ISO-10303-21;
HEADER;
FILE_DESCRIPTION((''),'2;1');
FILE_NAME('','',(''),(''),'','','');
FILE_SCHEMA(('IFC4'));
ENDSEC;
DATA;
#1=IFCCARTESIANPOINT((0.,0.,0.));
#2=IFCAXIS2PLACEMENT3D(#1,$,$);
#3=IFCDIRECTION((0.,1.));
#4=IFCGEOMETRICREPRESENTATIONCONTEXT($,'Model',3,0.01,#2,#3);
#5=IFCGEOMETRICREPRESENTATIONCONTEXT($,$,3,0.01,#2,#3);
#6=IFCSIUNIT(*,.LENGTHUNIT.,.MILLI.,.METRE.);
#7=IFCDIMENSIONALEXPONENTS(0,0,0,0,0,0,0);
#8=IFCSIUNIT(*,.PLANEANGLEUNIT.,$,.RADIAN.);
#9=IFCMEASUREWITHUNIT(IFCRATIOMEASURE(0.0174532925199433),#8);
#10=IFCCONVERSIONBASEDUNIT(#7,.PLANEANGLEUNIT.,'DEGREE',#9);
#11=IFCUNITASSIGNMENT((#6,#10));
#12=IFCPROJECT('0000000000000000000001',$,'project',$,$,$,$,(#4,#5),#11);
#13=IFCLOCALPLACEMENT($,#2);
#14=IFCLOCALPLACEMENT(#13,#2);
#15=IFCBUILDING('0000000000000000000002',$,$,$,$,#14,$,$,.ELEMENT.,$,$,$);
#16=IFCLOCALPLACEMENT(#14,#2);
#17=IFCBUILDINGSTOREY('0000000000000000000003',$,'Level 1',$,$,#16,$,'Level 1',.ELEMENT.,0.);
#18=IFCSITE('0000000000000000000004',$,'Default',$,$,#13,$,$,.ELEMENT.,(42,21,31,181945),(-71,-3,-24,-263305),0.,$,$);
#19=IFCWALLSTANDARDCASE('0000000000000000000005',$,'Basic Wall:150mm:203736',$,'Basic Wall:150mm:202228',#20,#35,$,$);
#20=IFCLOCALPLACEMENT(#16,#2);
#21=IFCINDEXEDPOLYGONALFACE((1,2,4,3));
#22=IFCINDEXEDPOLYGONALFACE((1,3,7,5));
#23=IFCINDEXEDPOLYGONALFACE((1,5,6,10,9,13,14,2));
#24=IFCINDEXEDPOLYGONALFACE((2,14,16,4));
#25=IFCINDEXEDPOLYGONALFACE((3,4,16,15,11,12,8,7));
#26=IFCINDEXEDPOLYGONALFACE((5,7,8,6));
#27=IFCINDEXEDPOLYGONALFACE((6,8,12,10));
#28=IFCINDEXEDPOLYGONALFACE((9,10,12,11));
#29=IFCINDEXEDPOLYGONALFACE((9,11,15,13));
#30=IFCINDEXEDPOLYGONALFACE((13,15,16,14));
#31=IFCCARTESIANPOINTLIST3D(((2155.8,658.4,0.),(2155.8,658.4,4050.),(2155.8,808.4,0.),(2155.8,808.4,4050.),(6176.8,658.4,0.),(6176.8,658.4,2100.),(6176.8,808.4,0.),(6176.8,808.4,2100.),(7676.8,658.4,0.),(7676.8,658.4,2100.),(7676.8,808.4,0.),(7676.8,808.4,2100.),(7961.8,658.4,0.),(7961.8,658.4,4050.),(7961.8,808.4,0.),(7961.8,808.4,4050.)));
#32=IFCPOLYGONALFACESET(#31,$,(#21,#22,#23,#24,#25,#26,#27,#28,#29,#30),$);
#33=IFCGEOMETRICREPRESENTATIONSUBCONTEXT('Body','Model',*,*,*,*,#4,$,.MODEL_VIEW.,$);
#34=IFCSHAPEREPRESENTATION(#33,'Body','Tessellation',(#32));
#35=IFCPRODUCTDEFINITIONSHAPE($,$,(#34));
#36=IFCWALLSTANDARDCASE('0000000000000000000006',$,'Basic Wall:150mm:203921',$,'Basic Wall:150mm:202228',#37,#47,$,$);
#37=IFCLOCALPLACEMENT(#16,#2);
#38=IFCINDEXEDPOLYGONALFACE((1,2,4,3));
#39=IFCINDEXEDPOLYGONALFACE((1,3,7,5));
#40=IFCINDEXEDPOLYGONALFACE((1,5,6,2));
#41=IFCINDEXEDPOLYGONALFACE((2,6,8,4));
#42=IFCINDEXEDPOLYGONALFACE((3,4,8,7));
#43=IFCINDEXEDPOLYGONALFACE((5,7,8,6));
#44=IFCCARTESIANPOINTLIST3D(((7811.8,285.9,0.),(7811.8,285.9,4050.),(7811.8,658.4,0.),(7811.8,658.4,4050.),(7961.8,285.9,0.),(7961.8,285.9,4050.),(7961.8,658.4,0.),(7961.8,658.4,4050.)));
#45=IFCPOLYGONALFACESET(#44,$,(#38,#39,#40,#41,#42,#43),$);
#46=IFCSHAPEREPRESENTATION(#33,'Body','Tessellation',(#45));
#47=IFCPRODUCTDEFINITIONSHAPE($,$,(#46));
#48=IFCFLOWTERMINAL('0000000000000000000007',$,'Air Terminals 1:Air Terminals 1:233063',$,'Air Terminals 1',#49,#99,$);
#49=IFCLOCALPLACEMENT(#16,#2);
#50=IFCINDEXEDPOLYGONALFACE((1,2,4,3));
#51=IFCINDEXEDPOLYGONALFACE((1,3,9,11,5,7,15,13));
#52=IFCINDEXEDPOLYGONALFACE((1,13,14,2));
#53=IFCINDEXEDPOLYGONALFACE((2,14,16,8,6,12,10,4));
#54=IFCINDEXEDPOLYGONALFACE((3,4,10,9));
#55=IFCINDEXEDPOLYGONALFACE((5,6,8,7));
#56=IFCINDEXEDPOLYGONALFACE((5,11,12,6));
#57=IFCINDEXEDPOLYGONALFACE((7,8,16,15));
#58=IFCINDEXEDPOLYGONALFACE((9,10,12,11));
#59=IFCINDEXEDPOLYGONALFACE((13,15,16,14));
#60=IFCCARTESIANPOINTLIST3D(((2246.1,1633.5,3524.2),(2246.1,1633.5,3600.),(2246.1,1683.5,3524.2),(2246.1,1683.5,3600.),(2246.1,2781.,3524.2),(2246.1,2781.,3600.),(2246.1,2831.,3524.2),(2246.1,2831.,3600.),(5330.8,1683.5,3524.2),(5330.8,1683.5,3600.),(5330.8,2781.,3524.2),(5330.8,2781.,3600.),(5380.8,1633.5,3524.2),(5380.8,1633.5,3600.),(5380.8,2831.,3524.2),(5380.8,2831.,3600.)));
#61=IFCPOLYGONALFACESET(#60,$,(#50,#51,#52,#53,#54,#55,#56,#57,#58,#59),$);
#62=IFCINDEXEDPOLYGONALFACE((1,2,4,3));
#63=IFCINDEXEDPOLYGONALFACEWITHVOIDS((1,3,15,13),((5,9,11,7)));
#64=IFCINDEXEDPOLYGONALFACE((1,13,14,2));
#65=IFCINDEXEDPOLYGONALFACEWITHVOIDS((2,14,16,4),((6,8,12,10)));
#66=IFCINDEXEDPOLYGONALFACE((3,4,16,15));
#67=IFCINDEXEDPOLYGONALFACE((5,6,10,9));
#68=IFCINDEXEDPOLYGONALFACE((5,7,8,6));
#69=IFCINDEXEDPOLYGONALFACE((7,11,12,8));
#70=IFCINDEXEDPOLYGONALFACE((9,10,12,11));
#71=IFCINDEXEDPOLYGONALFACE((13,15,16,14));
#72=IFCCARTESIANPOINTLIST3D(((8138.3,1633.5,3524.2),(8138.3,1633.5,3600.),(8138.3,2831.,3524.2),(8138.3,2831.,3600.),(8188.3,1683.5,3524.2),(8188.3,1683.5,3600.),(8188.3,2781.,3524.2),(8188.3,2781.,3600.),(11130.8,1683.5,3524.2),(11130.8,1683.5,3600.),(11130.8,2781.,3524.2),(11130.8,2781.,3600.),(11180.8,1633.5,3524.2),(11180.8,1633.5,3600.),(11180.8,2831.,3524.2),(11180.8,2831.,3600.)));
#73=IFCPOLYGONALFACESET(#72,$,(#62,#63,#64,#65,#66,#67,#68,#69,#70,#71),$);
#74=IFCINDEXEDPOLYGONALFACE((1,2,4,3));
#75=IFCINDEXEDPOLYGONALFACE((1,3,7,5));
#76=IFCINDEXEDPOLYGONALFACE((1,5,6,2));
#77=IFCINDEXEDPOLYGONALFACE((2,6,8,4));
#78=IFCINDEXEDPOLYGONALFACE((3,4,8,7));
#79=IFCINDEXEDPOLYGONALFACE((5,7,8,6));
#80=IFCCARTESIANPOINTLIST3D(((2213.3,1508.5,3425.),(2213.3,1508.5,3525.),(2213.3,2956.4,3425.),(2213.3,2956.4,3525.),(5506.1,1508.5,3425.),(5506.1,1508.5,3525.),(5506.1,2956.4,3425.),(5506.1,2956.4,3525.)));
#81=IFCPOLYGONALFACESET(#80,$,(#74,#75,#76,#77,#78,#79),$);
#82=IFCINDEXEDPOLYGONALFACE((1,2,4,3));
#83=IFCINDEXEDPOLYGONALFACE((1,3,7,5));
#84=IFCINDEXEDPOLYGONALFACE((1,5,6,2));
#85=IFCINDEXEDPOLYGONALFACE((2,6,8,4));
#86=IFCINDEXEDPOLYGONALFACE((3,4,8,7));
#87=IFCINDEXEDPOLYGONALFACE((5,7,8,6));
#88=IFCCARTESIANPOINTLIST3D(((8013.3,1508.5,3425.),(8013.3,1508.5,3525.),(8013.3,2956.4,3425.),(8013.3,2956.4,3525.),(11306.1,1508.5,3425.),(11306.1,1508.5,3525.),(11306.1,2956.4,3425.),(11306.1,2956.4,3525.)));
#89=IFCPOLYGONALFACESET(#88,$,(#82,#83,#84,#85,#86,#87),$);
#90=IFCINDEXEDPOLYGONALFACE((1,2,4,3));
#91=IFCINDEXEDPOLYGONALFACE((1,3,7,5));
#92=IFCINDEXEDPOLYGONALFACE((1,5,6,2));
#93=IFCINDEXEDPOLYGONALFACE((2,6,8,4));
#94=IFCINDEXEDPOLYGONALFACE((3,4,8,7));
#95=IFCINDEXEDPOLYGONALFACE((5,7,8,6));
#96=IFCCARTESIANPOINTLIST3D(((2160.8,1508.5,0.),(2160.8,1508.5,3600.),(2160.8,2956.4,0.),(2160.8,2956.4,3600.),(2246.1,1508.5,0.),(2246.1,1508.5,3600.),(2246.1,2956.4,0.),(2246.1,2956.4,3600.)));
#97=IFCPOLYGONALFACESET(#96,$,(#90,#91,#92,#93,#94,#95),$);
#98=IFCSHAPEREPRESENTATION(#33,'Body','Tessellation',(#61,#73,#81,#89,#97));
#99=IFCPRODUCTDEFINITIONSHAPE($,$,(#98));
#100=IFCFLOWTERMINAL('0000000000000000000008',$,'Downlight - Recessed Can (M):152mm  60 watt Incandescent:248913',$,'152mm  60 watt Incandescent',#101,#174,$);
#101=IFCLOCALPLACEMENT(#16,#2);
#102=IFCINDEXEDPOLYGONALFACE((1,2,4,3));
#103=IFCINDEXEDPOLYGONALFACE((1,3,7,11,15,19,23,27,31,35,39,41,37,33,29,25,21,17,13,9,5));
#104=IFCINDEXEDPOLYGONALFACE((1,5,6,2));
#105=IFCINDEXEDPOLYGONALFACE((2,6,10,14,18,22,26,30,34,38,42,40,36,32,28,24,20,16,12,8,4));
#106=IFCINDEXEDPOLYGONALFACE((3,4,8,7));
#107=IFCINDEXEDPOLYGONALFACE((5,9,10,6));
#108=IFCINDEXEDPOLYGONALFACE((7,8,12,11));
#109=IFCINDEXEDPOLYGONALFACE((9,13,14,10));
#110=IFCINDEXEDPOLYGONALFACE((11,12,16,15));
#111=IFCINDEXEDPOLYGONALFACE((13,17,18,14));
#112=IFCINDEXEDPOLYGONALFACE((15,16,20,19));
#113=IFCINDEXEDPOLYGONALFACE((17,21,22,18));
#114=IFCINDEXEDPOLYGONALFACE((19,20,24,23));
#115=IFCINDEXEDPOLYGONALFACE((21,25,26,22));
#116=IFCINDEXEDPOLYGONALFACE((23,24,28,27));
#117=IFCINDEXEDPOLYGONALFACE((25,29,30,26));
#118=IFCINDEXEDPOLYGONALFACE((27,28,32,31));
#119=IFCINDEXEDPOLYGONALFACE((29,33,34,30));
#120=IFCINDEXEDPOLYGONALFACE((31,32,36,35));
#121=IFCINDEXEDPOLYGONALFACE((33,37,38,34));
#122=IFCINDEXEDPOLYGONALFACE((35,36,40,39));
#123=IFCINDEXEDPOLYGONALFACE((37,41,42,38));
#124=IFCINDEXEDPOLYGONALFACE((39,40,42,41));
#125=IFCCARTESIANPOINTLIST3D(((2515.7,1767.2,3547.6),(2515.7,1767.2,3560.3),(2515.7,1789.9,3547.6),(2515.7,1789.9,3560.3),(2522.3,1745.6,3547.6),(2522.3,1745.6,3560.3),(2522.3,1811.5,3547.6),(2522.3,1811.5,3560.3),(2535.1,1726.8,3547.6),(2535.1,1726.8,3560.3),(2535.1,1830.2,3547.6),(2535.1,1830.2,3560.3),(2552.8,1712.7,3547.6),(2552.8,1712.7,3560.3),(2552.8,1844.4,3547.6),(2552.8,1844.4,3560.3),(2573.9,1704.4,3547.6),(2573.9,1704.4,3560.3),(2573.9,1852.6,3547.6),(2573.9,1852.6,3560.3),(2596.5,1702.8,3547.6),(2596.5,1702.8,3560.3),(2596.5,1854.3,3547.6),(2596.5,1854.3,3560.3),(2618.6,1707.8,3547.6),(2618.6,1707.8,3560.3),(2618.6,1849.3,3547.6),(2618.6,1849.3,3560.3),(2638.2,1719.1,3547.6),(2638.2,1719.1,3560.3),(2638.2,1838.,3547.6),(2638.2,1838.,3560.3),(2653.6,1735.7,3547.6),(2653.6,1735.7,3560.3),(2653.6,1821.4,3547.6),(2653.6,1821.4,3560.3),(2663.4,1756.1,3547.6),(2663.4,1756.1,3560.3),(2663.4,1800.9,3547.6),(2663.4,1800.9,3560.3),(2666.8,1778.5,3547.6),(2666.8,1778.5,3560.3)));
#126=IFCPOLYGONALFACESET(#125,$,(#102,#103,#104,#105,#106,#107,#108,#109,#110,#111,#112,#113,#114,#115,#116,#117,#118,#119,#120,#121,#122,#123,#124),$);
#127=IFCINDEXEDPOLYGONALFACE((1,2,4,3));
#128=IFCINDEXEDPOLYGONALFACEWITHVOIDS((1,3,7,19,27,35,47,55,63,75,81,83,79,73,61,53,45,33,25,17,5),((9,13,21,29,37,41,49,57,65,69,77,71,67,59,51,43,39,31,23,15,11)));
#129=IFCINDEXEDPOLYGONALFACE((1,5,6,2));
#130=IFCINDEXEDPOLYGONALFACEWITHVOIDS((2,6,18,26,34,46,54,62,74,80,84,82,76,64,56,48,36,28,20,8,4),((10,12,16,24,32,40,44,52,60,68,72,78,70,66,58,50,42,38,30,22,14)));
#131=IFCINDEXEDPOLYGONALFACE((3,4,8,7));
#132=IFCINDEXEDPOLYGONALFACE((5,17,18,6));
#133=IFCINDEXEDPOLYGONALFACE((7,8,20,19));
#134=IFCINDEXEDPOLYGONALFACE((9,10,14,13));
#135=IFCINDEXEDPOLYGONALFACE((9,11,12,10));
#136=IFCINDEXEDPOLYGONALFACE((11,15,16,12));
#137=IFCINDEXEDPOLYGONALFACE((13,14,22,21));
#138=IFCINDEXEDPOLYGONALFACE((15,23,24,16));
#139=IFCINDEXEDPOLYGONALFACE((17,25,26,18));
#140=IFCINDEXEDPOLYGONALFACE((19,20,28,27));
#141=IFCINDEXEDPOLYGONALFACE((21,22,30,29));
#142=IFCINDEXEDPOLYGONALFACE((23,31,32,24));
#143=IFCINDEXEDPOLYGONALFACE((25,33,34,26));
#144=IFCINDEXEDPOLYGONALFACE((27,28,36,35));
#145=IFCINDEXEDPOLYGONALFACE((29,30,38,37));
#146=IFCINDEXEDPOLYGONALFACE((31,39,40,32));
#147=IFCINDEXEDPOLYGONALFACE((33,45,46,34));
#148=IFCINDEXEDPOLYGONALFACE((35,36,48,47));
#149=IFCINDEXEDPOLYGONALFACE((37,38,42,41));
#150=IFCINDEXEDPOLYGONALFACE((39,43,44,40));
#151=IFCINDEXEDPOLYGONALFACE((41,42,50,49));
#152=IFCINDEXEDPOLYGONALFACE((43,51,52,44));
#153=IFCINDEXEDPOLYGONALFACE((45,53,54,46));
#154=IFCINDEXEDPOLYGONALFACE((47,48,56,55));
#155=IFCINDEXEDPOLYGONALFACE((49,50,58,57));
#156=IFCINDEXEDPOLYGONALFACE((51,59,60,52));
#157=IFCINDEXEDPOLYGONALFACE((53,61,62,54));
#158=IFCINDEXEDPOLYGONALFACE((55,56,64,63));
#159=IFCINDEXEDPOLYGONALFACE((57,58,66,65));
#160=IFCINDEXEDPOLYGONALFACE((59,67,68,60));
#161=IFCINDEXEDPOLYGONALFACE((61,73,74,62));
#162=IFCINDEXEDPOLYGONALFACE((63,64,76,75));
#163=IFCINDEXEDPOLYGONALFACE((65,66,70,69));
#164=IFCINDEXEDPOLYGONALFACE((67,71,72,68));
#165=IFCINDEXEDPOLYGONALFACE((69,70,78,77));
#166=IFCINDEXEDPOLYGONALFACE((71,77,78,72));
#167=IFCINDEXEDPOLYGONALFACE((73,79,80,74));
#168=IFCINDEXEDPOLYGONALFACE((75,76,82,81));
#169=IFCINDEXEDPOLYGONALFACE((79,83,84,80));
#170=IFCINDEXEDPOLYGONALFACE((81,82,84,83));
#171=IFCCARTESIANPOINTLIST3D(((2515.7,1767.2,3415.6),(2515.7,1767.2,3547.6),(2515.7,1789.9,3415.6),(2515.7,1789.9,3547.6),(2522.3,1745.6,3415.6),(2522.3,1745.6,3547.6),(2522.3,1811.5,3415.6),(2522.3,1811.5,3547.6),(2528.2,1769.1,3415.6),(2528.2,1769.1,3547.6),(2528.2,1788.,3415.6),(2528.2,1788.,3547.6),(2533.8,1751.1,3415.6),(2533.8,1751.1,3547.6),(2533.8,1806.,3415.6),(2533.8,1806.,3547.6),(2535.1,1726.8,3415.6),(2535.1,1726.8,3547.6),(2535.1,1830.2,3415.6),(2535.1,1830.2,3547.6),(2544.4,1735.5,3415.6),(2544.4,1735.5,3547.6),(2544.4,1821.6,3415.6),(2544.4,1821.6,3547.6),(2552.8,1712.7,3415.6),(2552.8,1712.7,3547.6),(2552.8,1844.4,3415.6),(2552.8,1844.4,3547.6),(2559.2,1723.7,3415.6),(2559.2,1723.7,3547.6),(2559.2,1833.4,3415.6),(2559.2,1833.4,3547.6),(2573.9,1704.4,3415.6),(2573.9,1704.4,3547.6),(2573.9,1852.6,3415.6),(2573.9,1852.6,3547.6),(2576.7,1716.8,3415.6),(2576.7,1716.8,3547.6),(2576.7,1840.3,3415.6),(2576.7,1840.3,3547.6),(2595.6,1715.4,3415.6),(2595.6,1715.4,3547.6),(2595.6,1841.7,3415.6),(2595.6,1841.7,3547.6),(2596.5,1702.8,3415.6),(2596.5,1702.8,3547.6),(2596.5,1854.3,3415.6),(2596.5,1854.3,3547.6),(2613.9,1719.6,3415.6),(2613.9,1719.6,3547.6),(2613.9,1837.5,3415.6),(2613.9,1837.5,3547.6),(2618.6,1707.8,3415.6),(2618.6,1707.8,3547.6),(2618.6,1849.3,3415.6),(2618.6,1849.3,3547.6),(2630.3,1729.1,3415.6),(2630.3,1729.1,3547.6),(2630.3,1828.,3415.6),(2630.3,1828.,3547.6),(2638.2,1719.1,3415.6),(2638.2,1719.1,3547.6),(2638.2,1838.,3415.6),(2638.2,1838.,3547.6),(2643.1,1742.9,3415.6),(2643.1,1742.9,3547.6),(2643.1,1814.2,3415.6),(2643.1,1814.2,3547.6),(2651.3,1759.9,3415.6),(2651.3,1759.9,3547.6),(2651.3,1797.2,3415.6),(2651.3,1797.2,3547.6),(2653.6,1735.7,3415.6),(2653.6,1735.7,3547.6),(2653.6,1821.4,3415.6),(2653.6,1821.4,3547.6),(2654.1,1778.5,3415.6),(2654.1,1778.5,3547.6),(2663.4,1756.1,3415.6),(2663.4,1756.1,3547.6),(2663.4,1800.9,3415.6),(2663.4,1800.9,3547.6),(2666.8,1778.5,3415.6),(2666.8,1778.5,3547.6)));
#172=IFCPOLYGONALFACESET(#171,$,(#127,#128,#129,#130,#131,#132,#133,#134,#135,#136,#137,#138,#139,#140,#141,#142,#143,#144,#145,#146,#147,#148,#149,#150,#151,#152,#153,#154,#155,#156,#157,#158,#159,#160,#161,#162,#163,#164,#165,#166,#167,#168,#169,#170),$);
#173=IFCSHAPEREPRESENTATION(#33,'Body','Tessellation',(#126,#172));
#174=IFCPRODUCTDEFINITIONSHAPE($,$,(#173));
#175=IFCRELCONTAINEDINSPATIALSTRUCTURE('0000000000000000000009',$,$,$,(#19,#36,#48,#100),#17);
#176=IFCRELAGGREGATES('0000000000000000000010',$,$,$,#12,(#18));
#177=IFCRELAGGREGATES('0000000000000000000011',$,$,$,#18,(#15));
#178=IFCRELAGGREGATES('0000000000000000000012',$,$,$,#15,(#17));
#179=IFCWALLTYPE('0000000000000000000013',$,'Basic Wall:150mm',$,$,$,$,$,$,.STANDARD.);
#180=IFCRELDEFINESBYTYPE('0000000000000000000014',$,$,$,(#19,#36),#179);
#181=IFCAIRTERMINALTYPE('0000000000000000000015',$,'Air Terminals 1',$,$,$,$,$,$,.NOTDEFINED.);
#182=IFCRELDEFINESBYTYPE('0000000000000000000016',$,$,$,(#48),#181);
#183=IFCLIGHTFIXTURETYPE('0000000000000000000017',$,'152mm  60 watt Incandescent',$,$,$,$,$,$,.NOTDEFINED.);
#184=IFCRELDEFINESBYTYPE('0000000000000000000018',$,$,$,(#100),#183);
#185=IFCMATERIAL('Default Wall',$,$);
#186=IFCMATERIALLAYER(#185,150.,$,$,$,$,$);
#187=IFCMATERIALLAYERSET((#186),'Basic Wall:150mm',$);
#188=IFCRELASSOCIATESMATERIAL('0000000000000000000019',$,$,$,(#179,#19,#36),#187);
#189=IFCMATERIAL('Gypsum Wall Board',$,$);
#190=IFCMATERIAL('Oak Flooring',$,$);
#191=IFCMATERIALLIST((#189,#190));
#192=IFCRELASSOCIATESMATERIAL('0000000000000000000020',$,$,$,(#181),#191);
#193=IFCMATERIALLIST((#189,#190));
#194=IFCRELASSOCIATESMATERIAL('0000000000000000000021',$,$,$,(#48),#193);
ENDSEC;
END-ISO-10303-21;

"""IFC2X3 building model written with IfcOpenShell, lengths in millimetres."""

from ifc_helpers import new_model, entity, si_unit, converted_unit, direction, frame, frame_2d, origin, origin_2d_with_axis, place, context, subcontext, project, spatial, polyline, rectangle, circle, hollow_circle, outline, extrude, source, transform, mapped, material, material_list, layer, layer_set, layer_usage, type_object, type_shapes, element, save


model = new_model("IFC2X3")

# Units and contexts
model_context = context("Model", 3, precision=0.01, world=origin(), true_north=direction((0.0, 1.0)))
context_of_model = context(None, 3, precision=0.01, world=origin(), true_north=direction((0.0, 1.0)))
body_context = subcontext(model_context, "Body", "Model", "MODEL_VIEW")
ifc_project = project(units=[si_unit("LENGTHUNIT", "METRE", prefix="MILLI"), converted_unit("PLANEANGLEUNIT", "DEGREE", entity("IfcRatioMeasure", 0.0174532925199433), si_unit("PLANEANGLEUNIT", "RADIAN"), dimensions=[0, 0, 0, 0, 0, 0, 0])], contexts=[model_context, context_of_model])

# Site, building, storey
site_placement = place(None, origin())
site = spatial("IfcSite", under=ifc_project, at=site_placement, Name="Default", CompositionType="ELEMENT", RefLatitude=(42, 21, 31, 181945), RefLongitude=(-71, -3, -24, -263305), RefElevation=0.0)
building_placement = place(site_placement, origin())
building = spatial("IfcBuilding", under=site, at=building_placement, CompositionType="ELEMENT")
storey_placement = place(building_placement, origin())
storey = spatial("IfcBuildingStorey", under=building, at=storey_placement, Name="Level 1", LongName="Level 1", CompositionType="ELEMENT", Elevation=0.0)

# Shared definitions
ifc_material_1 = material(Name="Default Wall")

# Shared definitions
ifc_layer_1 = layer(ifc_material_1, 150.0)
ifc_layer_set_1 = layer_set([ifc_layer_1], Name="Basic Wall:150mm")
wall_type_1 = type_object("IfcWallType", Name="Basic Wall:150mm", PredefinedType="STANDARD", material=ifc_layer_set_1)

# Wall, opening
ifc_layer_usage_1 = layer_usage(ifc_layer_set_1, "AXIS2", "NEGATIVE", 75.0)
wall_1_placement = place(storey_placement, frame((2155.8, 733.4, 0.0)))
wall_1 = element("IfcWallStandardCase", 1, at=wall_1_placement, inside=storey, type_object=wall_type_1, material=ifc_layer_usage_1, Name="Basic Wall:150mm:203736", ObjectType="Basic Wall:150mm:202228", context=body_context, shape_type="SweptSolid", body=[
    extrude(rectangle(XDim=5806.0, YDim=150.0, at=frame_2d((2903.0, 0.0), x_axis=(-1.0, 0.0))), origin(), (0.0, 0.0, 1.0), 4050.0),
])
opening_1_placement = place(wall_1_placement, frame((5521.0, 75.0, 0.0)))
element("IfcOpeningElement", 2, at=opening_1_placement, cuts=wall_1, ObjectType="Opening", context=body_context, shape_type="SweptSolid", body=[
    extrude(rectangle(XDim=2100.0, YDim=1500.0, at=frame_2d((1050.0, 750.0), x_axis=(1.0, 0.0))), frame((0.0, 0.0, 0.0), z_axis=(0.0, -1.0, 0.0), x_axis=(0.0, 0.0, 1.0)), (0.0, 0.0, 1.0), 150.0),
])

# Wall
ifc_layer_usage_2 = layer_usage(ifc_layer_set_1, "AXIS2", "NEGATIVE", 75.0)
wall_2_placement = place(storey_placement, frame((7886.8, 658.4, 0.0), z_axis=(0.0, 0.0, 1.0), x_axis=(0.0, -1.0, 0.0)))
element("IfcWallStandardCase", 3, at=wall_2_placement, inside=storey, type_object=wall_type_1, material=ifc_layer_usage_2, Name="Basic Wall:150mm:203921", ObjectType="Basic Wall:150mm:202228", context=body_context, shape_type="SweptSolid", body=[
    extrude(rectangle(XDim=372.5, YDim=150.0, at=frame_2d((186.2, 0.0), x_axis=(-1.0, 0.0))), origin(), (0.0, 0.0, 1.0), 4050.0),
])

# Shared definitions
ifc_material_2 = material(Name="Gypsum Wall Board")

# Flow terminals
ifc_material_3 = material(Name="Oak Flooring")
ifc_material_list_1 = material_list([ifc_material_2, ifc_material_3])
ifc_material_list_2 = material_list([ifc_material_2, ifc_material_3])
air_terminal_type = type_object("IfcAirTerminalType", Name="Air Terminals 1", PredefinedType="NOTDEFINED", material=ifc_material_list_2)
shared_shape_1 = source(origin(), body_context, "Body", "SweptSolid", [
    extrude(outline(polyline([(-1554.9, -598.8), (1579.9, -598.8), (1579.9, 598.7), (-1554.9, 598.7), (-1554.9, 548.7), (1529.9, 548.7), (1529.9, -548.8), (-1554.9, -548.8), (-1554.9, -598.8)])), frame((3800.9, 2232.2, 3524.2)), (0.0, 0.0, 1.0), 75.8),
    extrude(outline(polyline([(-1521.2, -598.8), (1521.2, -598.8), (1521.2, 598.7), (-1521.2, 598.7), (-1521.2, -598.8)]), holes=[polyline([(-1471.2, -548.8), (-1471.2, 548.7), (1471.2, 548.7), (1471.2, -548.8), (-1471.2, -548.8)])]), frame((9659.6, 2232.2, 3524.2)), (0.0, 0.0, 1.0), 75.8),
    extrude(rectangle(XDim=1447.9, YDim=3292.8, at=frame_2d((0.0, 0.0), x_axis=(1.0, 0.0))), frame((3859.7, 2232.5, 3425.0), z_axis=(0.0, 0.0, 1.0), x_axis=(0.0, 1.0, 0.0)), (0.0, 0.0, 1.0), 100.0),
    extrude(rectangle(XDim=1447.9, YDim=3292.8, at=origin_2d_with_axis()), frame((9659.7, 2232.5, 3425.0), z_axis=(0.0, 0.0, 1.0), x_axis=(0.0, 1.0, 0.0)), (0.0, 0.0, 1.0), 100.0),
    extrude(rectangle(XDim=85.2, YDim=1447.9, at=origin_2d_with_axis()), frame((2203.4, 2232.5, 0.0), z_axis=(0.0, 0.0, 1.0), x_axis=(-1.0, 0.0, 0.0)), (0.0, 0.0, 1.0), 3600.0),
])
type_shapes(air_terminal_type, [shared_shape_1])
flow_terminal_1_placement = place(storey_placement, origin())
element("IfcFlowTerminal", 4, at=flow_terminal_1_placement, inside=storey, type_object=air_terminal_type, material=ifc_material_list_1, Name="Air Terminals 1:Air Terminals 1:233063", ObjectType="Air Terminals 1", context=body_context, shape_type="MappedRepresentation", body=[
    mapped(shared_shape_1, transform((0.0, 0.0, 0.0), scale=1.0)),
])
light_fixture_type_1 = type_object("IfcLightFixtureType", Name="152mm  60 watt Incandescent", PredefinedType="NOTDEFINED")
shared_shape_2 = source(origin(), body_context, "Body", "SweptSolid", [
    extrude(circle(Radius=76.0, at=frame_2d((0.0, 0.0), x_axis=(1.0, 0.0))), frame((0.0, 0.0, 2628.7)), (0.0, 0.0, 1.0), 12.7),
    extrude(hollow_circle(Radius=76.0, WallThickness=12.7, at=frame_2d((0.0, 0.0), x_axis=(1.0, 0.0))), frame((0.0, 0.0, 2496.7)), (0.0, 0.0, 1.0), 132.0),
])
type_shapes(light_fixture_type_1, [shared_shape_2])
for number, where, name in (
    (5, (2590.8, 1778.5, 918.9), "Downlight - Recessed Can (M):152mm  60 watt Incandescent:248913"),
):
    element("IfcFlowTerminal", number, at=place(storey_placement, frame(where)), inside=storey, type_object=light_fixture_type_1, Name=name, ObjectType="152mm  60 watt Incandescent", context=body_context, shape_type="MappedRepresentation", body=[
        mapped(shared_shape_2, transform((0.0, 0.0, 0.0), scale=1.0)),
    ])

save(model, "model.ifc")
